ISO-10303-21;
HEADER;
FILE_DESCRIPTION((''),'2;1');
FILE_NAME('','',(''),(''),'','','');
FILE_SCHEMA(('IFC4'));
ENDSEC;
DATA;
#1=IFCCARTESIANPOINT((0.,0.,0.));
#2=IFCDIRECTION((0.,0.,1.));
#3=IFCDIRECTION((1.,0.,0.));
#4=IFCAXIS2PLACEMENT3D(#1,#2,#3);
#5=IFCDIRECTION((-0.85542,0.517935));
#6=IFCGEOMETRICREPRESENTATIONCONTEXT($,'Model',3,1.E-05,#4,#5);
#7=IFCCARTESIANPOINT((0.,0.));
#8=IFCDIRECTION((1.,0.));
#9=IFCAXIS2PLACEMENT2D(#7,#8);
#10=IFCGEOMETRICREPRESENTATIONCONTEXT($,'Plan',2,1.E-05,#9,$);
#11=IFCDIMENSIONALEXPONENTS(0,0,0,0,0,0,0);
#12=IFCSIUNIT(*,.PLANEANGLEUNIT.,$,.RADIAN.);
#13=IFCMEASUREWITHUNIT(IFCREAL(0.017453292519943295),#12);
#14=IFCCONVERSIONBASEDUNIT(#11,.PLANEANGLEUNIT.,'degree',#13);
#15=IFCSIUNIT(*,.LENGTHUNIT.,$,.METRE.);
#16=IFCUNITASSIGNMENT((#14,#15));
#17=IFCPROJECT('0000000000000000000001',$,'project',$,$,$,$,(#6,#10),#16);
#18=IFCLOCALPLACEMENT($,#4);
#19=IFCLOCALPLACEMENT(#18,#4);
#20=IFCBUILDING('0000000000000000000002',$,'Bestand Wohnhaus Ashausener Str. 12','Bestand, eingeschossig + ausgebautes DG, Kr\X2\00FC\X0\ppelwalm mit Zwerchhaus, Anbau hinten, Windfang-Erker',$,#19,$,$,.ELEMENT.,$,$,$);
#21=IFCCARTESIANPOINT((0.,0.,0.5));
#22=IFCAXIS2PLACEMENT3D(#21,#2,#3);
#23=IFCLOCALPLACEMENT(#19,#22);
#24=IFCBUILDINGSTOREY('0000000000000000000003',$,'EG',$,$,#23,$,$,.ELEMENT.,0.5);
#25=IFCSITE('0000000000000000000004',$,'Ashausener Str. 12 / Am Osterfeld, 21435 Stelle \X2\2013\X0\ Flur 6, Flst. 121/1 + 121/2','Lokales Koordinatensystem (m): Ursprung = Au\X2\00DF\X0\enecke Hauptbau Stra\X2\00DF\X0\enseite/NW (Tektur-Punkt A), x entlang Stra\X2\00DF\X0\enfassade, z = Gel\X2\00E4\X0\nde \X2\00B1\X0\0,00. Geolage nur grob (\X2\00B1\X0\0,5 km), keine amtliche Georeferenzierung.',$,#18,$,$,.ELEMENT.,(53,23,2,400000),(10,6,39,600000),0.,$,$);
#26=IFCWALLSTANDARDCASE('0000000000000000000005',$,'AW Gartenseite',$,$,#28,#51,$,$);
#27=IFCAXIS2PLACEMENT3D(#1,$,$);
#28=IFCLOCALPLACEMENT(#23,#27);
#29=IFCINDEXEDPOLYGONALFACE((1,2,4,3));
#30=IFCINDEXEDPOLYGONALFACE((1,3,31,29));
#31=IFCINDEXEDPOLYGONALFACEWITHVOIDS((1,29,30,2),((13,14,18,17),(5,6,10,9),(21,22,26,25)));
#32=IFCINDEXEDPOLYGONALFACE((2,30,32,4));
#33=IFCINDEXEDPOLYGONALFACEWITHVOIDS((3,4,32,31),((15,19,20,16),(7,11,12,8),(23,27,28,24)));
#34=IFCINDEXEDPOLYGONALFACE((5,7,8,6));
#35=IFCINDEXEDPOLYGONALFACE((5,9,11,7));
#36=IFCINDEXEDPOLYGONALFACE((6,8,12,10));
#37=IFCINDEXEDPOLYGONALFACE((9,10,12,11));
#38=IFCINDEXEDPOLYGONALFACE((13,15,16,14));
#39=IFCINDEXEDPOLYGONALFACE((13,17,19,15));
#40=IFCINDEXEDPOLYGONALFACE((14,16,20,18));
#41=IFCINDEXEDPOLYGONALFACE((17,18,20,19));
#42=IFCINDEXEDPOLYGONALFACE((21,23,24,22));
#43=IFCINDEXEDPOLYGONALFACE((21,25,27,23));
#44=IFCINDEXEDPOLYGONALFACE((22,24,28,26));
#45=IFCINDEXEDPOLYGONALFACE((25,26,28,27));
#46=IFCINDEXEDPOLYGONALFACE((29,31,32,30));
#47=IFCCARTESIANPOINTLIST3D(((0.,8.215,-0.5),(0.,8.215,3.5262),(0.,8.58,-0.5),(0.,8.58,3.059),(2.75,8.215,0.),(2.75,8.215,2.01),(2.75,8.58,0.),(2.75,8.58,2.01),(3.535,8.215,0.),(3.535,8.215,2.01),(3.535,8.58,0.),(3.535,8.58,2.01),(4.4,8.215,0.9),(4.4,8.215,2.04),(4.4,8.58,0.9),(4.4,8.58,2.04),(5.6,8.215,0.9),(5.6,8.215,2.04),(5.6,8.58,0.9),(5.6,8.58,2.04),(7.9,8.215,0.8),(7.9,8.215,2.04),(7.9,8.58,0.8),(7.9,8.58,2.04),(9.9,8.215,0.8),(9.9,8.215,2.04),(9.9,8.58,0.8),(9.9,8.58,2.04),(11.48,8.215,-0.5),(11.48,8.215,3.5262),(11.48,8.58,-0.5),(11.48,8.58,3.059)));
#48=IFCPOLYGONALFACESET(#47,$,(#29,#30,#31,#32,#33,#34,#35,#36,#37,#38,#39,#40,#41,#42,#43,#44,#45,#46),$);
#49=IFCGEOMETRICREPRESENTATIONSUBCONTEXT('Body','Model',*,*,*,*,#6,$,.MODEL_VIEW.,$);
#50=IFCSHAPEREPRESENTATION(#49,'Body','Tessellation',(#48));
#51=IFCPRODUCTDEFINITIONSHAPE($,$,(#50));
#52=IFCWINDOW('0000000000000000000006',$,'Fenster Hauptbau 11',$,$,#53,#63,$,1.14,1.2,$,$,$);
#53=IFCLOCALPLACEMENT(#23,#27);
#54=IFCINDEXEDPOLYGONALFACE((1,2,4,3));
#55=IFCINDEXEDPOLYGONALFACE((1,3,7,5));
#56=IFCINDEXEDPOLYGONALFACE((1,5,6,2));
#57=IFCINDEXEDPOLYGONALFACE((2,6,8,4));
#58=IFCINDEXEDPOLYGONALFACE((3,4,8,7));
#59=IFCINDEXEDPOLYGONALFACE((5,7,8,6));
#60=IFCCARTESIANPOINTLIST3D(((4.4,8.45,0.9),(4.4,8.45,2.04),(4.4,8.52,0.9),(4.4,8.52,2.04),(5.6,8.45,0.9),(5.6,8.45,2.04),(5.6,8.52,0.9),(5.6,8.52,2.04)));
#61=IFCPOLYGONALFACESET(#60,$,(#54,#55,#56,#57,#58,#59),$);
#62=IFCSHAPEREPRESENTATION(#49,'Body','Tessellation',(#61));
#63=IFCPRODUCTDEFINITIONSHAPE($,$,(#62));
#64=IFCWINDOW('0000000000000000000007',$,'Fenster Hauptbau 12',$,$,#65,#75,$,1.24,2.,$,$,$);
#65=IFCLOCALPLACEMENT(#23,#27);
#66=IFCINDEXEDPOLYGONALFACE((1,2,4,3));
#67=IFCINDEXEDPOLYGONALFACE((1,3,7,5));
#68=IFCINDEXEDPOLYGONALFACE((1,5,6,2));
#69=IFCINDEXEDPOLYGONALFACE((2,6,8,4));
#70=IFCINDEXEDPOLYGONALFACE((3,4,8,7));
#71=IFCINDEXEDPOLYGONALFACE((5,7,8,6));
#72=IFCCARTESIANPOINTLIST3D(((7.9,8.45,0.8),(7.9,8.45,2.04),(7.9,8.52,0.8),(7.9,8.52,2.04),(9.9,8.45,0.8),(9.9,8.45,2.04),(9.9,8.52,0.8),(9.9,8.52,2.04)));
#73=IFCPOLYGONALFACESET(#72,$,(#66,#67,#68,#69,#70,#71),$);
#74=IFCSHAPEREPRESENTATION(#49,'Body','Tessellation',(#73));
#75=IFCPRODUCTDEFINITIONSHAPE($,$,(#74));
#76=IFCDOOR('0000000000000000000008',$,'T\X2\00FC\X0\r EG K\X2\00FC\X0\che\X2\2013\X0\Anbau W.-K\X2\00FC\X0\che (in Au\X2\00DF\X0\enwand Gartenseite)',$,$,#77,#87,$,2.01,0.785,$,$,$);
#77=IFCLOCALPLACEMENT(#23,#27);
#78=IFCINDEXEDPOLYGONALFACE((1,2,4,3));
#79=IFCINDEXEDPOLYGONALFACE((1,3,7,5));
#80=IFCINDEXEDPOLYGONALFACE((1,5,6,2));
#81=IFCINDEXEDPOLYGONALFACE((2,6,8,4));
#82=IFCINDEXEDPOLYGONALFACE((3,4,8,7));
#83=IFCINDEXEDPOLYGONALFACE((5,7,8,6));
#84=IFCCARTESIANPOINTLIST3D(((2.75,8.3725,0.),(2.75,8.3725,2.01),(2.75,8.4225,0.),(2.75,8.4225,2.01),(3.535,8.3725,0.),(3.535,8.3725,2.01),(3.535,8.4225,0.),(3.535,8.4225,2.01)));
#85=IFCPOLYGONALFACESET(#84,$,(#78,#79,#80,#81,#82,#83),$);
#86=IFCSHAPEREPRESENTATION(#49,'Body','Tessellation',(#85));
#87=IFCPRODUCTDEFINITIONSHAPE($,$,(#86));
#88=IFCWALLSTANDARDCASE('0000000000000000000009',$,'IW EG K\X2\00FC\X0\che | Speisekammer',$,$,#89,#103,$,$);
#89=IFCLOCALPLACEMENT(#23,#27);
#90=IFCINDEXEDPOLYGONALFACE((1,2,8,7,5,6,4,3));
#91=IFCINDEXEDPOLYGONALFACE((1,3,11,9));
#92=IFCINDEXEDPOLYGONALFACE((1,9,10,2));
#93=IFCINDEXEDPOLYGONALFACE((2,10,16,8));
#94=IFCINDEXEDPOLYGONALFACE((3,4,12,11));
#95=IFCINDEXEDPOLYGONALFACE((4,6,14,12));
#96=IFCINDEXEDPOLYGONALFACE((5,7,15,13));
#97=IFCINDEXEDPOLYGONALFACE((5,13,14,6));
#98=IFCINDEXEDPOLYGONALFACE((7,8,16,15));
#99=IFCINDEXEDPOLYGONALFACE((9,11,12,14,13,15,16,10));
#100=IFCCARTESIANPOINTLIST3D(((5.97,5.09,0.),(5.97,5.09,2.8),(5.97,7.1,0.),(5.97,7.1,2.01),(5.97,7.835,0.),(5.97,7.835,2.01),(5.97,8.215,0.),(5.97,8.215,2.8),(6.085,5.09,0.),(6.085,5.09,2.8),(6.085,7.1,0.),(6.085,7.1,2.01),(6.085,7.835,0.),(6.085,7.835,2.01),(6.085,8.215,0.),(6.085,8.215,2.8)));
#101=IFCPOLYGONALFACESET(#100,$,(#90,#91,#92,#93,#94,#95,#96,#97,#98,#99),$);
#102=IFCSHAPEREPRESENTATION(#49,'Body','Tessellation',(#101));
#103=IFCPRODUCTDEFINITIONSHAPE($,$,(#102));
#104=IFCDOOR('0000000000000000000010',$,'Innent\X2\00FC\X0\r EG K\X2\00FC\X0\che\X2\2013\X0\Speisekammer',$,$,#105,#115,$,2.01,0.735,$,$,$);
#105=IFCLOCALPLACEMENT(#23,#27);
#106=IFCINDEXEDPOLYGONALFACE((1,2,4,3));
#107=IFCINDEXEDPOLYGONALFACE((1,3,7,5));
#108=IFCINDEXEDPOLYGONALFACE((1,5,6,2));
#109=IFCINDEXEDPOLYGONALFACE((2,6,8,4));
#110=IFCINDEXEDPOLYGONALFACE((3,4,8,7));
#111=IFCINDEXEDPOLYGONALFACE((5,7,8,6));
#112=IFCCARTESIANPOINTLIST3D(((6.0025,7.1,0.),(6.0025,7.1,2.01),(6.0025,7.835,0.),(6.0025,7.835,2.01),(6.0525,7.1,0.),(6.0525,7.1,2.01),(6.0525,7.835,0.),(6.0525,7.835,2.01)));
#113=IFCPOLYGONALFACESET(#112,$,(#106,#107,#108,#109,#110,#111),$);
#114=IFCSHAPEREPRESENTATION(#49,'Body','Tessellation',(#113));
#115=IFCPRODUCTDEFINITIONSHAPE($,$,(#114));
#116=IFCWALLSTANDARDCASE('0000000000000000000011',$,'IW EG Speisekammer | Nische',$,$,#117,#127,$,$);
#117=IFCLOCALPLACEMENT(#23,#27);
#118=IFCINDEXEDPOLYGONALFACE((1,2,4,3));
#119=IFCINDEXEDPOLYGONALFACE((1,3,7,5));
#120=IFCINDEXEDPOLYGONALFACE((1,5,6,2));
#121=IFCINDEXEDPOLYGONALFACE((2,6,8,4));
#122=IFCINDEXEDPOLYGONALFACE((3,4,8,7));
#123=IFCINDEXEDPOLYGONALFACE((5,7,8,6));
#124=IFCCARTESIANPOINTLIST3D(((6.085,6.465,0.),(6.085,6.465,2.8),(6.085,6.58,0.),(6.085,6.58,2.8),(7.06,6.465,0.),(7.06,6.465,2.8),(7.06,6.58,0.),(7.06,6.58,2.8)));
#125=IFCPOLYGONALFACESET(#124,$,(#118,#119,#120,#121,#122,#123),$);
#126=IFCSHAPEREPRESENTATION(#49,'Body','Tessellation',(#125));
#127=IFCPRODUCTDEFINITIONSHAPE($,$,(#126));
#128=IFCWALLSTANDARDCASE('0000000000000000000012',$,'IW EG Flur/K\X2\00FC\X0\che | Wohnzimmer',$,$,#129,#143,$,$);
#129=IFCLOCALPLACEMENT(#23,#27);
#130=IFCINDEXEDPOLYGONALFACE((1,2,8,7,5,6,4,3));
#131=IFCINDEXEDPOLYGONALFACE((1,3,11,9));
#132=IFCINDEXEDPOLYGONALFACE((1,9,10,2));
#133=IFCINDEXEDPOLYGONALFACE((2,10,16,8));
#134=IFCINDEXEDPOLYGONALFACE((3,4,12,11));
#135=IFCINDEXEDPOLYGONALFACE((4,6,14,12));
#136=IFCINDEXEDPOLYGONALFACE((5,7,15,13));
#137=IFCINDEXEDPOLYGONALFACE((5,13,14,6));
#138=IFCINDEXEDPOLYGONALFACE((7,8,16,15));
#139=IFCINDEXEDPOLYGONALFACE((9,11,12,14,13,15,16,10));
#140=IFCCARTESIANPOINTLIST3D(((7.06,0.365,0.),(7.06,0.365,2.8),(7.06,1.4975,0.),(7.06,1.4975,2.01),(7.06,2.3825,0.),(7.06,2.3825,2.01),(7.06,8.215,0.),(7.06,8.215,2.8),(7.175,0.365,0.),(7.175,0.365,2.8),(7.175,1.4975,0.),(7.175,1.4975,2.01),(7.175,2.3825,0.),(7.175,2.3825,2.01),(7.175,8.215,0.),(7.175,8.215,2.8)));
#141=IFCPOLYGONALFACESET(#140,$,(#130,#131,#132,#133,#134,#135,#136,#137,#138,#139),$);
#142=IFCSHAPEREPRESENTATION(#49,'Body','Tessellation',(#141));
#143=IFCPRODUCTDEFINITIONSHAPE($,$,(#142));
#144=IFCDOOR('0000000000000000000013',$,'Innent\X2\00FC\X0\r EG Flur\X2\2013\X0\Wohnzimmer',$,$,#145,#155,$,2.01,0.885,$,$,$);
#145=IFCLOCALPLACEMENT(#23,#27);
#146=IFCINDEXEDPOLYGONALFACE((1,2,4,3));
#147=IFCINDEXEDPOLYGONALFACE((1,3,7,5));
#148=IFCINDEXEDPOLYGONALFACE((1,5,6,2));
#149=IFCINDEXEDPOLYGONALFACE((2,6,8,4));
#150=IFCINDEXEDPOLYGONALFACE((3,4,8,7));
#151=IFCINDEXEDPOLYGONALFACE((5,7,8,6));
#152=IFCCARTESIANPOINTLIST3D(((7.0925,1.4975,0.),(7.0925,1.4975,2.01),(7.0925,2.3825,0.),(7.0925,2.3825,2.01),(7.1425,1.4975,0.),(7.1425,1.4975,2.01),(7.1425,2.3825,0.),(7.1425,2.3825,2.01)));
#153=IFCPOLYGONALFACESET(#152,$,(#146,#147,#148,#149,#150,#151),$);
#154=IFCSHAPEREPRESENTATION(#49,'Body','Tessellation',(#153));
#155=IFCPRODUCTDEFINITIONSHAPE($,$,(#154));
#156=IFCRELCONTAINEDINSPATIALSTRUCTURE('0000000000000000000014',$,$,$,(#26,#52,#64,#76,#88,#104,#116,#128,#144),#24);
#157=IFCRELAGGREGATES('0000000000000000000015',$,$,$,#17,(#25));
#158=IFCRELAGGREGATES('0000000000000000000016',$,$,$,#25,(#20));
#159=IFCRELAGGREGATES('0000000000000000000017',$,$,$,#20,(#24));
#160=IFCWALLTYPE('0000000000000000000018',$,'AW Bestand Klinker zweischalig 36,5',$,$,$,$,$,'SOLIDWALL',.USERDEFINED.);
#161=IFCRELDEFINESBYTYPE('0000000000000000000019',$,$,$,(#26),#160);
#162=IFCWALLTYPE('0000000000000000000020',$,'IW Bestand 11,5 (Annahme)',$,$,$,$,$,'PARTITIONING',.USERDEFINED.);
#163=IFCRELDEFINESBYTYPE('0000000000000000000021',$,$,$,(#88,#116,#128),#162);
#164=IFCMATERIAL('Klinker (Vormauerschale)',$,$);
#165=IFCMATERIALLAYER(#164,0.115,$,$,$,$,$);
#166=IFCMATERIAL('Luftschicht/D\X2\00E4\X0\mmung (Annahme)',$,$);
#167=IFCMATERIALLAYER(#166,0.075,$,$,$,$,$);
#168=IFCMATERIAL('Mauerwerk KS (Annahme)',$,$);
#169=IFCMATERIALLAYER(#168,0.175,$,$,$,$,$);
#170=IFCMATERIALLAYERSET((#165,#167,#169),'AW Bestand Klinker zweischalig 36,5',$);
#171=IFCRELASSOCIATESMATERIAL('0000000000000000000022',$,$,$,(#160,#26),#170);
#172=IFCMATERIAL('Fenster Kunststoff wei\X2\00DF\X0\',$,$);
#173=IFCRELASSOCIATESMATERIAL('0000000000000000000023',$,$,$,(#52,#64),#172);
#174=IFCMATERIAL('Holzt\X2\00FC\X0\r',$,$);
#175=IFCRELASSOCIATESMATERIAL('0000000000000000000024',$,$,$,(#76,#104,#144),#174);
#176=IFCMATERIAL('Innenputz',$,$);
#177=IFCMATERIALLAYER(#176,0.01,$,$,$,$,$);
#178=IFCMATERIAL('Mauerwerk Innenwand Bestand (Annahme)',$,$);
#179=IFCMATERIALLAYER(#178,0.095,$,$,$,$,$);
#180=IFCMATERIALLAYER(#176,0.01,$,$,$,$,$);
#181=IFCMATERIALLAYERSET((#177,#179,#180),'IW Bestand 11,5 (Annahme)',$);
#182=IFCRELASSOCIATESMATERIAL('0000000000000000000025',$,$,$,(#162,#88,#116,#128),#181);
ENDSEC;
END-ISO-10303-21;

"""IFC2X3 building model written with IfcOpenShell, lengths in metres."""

from ifc_helpers import new_model, entity, si_unit, converted_unit, direction, frame, origin_with_axes, origin_2d_with_axis, place, context, subcontext, project, spatial, polyline, outline, extrude, clip, halfspace, material, layer, layer_set, layer_usage, type_object, element, fill, save


model = new_model("IFC2X3")

# Units and contexts
model_context = context("Model", 3, precision=1e-05, world=origin_with_axes(), true_north=direction((-0.85542, 0.517935)))
plan_context = context("Plan", 2, precision=1e-05, world=origin_2d_with_axis())
body_context = subcontext(model_context, "Body", "Model", "MODEL_VIEW")
ifc_project = project(units=[converted_unit("PLANEANGLEUNIT", "degree", entity("IfcReal", 0.017453292519943295), si_unit("PLANEANGLEUNIT", "RADIAN"), dimensions=[0, 0, 0, 0, 0, 0, 0]), si_unit("LENGTHUNIT", "METRE")], contexts=[model_context, plan_context])

# Site, building, storey
site_placement = place(None, origin_with_axes())
site = spatial("IfcSite", under=ifc_project, at=site_placement, Name="Ashausener Str. 12 / Am Osterfeld, 21435 Stelle – Flur 6, Flst. 121/1 + 121/2", Description="Lokales Koordinatensystem (m): Ursprung = Außenecke Hauptbau Straßenseite/NW (Tektur-Punkt A), x entlang Straßenfassade, z = Gelände ±0,00. Geolage nur grob (±0,5 km), keine amtliche Georeferenzierung.", CompositionType="ELEMENT", RefLatitude=(53, 23, 2, 400000), RefLongitude=(10, 6, 39, 600000), RefElevation=0.0)
building_placement = place(site_placement, origin_with_axes())
building = spatial("IfcBuilding", under=site, at=building_placement, Name="Bestand Wohnhaus Ashausener Str. 12", Description="Bestand, eingeschossig + ausgebautes DG, Krüppelwalm mit Zwerchhaus, Anbau hinten, Windfang-Erker", CompositionType="ELEMENT")
storey_placement = place(building_placement, frame((0.0, 0.0, 0.5), z_axis=(0.0, 0.0, 1.0), x_axis=(1.0, 0.0, 0.0)))
storey = spatial("IfcBuildingStorey", under=building, at=storey_placement, Name="EG", CompositionType="ELEMENT", Elevation=0.5)

# Wall, openings, windows, door
ifc_material_1 = material(Name="Klinker (Vormauerschale)")
ifc_layer_1 = layer(ifc_material_1, 0.115)
ifc_material_2 = material(Name="Luftschicht/Dämmung (Annahme)")
ifc_layer_2 = layer(ifc_material_2, 0.075)
ifc_material_3 = material(Name="Mauerwerk KS (Annahme)")
ifc_layer_3 = layer(ifc_material_3, 0.175)
ifc_layer_set_1 = layer_set([ifc_layer_1, ifc_layer_2, ifc_layer_3], Name="AW Bestand Klinker zweischalig 36,5")
ifc_layer_usage_1 = layer_usage(ifc_layer_set_1, "AXIS2", "POSITIVE", 0.0)
wall_type_1 = type_object("IfcWallType", Name="AW Bestand Klinker zweischalig 36,5", ElementType="SOLIDWALL", PredefinedType="USERDEFINED", material=ifc_layer_set_1)
wall_1_placement = place(storey_placement, frame((11.48, 8.58, -0.5), z_axis=(0.0, 0.0, 1.0), x_axis=(-1.0, 0.0, 0.0)))
wall_1 = element("IfcWallStandardCase", 1, at=wall_1_placement, inside=storey, type_object=wall_type_1, material=ifc_layer_usage_1, Name="AW Gartenseite", context=body_context, shape_type="Clipping", body=[
    clip(clip(clip(clip(extrude(outline(polyline([(0.0, 0.0), (0.0, 0.365), (11.48, 0.365), (11.48, 0.0), (0.0, 0.0)])), origin_with_axes(), (0.0, 0.0, 1.0), 12.0), halfspace(frame((-0.39, 8.58, 5.9), z_axis=(-0.76604, 0.0, 0.64279), x_axis=(0.0, 1.0, 0.0)), False)), halfspace(frame((11.87, 8.58, 5.9), z_axis=(0.76604, 0.0, 0.64279), x_axis=(0.0, -1.0, 0.0)), False)), halfspace(frame((11.48, 4.29, 9.05), z_axis=(0.0, -0.78801, 0.61566), x_axis=(-1.0, 0.0, 0.0)), False)), halfspace(frame((11.48, 4.29, 9.05), z_axis=(0.0, 0.78801, 0.61566), x_axis=(1.0, 0.0, 0.0)), False)),
])
opening_1_placement = place(wall_1_placement, frame((5.88, -0.1, 1.4), z_axis=(0.0, 0.0, 1.0), x_axis=(1.0, 0.0, 0.0)))
opening_1 = element("IfcOpeningElement", 2, at=opening_1_placement, cuts=wall_1, context=body_context, shape_type="SweptSolid", body=[
    extrude(outline(polyline([(0.0, 0.0), (0.0, 0.565), (1.2, 0.565), (1.2, 0.0), (0.0, 0.0)])), origin_with_axes(), (0.0, 0.0, 1.0), 1.14),
])
opening_2_placement = place(wall_1_placement, frame((1.58, -0.1, 1.3), z_axis=(0.0, 0.0, 1.0), x_axis=(1.0, 0.0, 0.0)))
opening_2 = element("IfcOpeningElement", 3, at=opening_2_placement, cuts=wall_1, context=body_context, shape_type="SweptSolid", body=[
    extrude(outline(polyline([(0.0, 0.0), (0.0, 0.565), (2.0, 0.565), (2.0, 0.0), (0.0, 0.0)])), origin_with_axes(), (0.0, 0.0, 1.0), 1.24),
])
opening_3_placement = place(wall_1_placement, frame((7.945, -0.1, 0.5), z_axis=(0.0, 0.0, 1.0), x_axis=(1.0, 0.0, 0.0)))
opening_3 = element("IfcOpeningElement", 4, at=opening_3_placement, cuts=wall_1, context=body_context, shape_type="SweptSolid", body=[
    extrude(outline(polyline([(0.0, 0.0), (0.0, 0.565), (0.785, 0.565), (0.785, 0.0), (0.0, 0.0)])), origin_with_axes(), (0.0, 0.0, 1.0), 2.01),
])
ifc_material_4 = material(Name="Fenster Kunststoff weiß")
window_1_placement = place(storey_placement, frame((5.6, 8.52, 0.9), z_axis=(0.0, 0.0, 1.0), x_axis=(-1.0, 0.0, 0.0)))
window_1 = element("IfcWindow", 5, at=window_1_placement, inside=storey, material=ifc_material_4, Name="Fenster Hauptbau 11", OverallHeight=1.14, OverallWidth=1.2, context=body_context, shape_type="SweptSolid", body=[
    extrude(outline(polyline([(0.0, 0.0), (0.0, 0.07), (1.2, 0.07), (1.2, 0.0), (0.0, 0.0)])), origin_with_axes(), (0.0, 0.0, 1.0), 1.14),
])
fill(opening_1, window_1)
window_2_placement = place(storey_placement, frame((9.9, 8.52, 0.8), z_axis=(0.0, 0.0, 1.0), x_axis=(-1.0, 0.0, 0.0)))
window_2 = element("IfcWindow", 6, at=window_2_placement, inside=storey, material=ifc_material_4, Name="Fenster Hauptbau 12", OverallHeight=1.24, OverallWidth=2.0, context=body_context, shape_type="SweptSolid", body=[
    extrude(outline(polyline([(0.0, 0.0), (0.0, 0.07), (2.0, 0.07), (2.0, 0.0), (0.0, 0.0)])), origin_with_axes(), (0.0, 0.0, 1.0), 1.24),
])
fill(opening_2, window_2)
ifc_material_5 = material(Name="Holztür")
door_1_placement = place(storey_placement, frame((3.535, 8.4225, 0.0), z_axis=(0.0, 0.0, 1.0), x_axis=(-1.0, 0.0, 0.0)))
door_1 = element("IfcDoor", 7, at=door_1_placement, inside=storey, material=ifc_material_5, Name="Tür EG Küche–Anbau W.-Küche (in Außenwand Gartenseite)", OverallHeight=2.01, OverallWidth=0.785, context=body_context, shape_type="SweptSolid", body=[
    extrude(outline(polyline([(0.0, 0.0), (0.0, 0.05), (0.785, 0.05), (0.785, 0.0), (0.0, 0.0)])), origin_with_axes(), (0.0, 0.0, 1.0), 2.01),
])
fill(opening_3, door_1)

# Wall, opening, door
ifc_material_6 = material(Name="Innenputz")
ifc_layer_4 = layer(ifc_material_6, 0.01)
ifc_material_7 = material(Name="Mauerwerk Innenwand Bestand (Annahme)")
ifc_layer_5 = layer(ifc_material_7, 0.095)
ifc_layer_6 = layer(ifc_material_6, 0.01)
ifc_layer_set_2 = layer_set([ifc_layer_4, ifc_layer_5, ifc_layer_6], Name="IW Bestand 11,5 (Annahme)")
ifc_layer_usage_2 = layer_usage(ifc_layer_set_2, "AXIS2", "POSITIVE", 0.0)
wall_type_2 = type_object("IfcWallType", Name="IW Bestand 11,5 (Annahme)", ElementType="PARTITIONING", PredefinedType="USERDEFINED", material=ifc_layer_set_2)
wall_2_placement = place(storey_placement, frame((5.97, 8.215, 0.0), z_axis=(0.0, 0.0, 1.0), x_axis=(0.0, -1.0, 0.0)))
wall_2 = element("IfcWallStandardCase", 8, at=wall_2_placement, inside=storey, type_object=wall_type_2, material=ifc_layer_usage_2, Name="IW EG Küche | Speisekammer", context=body_context, shape_type="SweptSolid", body=[
    extrude(outline(polyline([(0.0, 0.0), (0.0, 0.115), (3.125, 0.115), (3.125, 0.0), (0.0, 0.0)])), origin_with_axes(), (0.0, 0.0, 1.0), 2.8),
])
opening_4_placement = place(wall_2_placement, frame((0.38, -0.1, 0.0), z_axis=(0.0, 0.0, 1.0), x_axis=(1.0, 0.0, 0.0)))
opening_4 = element("IfcOpeningElement", 9, at=opening_4_placement, cuts=wall_2, context=body_context, shape_type="SweptSolid", body=[
    extrude(outline(polyline([(0.0, 0.0), (0.0, 0.315), (0.735, 0.315), (0.735, 0.0), (0.0, 0.0)])), origin_with_axes(), (0.0, 0.0, 1.0), 2.01),
])
door_2_placement = place(storey_placement, frame((6.0025, 7.835, 0.0), z_axis=(0.0, 0.0, 1.0), x_axis=(0.0, -1.0, 0.0)))
door_2 = element("IfcDoor", 10, at=door_2_placement, inside=storey, material=ifc_material_5, Name="Innentür EG Küche–Speisekammer", OverallHeight=2.01, OverallWidth=0.735, context=body_context, shape_type="SweptSolid", body=[
    extrude(outline(polyline([(0.0, 0.0), (0.0, 0.05), (0.735, 0.05), (0.735, 0.0), (0.0, 0.0)])), origin_with_axes(), (0.0, 0.0, 1.0), 2.01),
])
fill(opening_4, door_2)

# Wall
ifc_layer_usage_3 = layer_usage(ifc_layer_set_2, "AXIS2", "POSITIVE", 0.0)
wall_3_placement = place(storey_placement, frame((6.085, 6.465, 0.0), z_axis=(0.0, 0.0, 1.0), x_axis=(1.0, 0.0, 0.0)))
element("IfcWallStandardCase", 11, at=wall_3_placement, inside=storey, type_object=wall_type_2, material=ifc_layer_usage_3, Name="IW EG Speisekammer | Nische", context=body_context, shape_type="SweptSolid", body=[
    extrude(outline(polyline([(0.0, 0.0), (0.0, 0.115), (0.975, 0.115), (0.975, 0.0), (0.0, 0.0)])), origin_with_axes(), (0.0, 0.0, 1.0), 2.8),
])

# Wall, opening, door
ifc_layer_usage_4 = layer_usage(ifc_layer_set_2, "AXIS2", "POSITIVE", 0.0)
wall_4_placement = place(storey_placement, frame((7.06, 8.215, 0.0), z_axis=(0.0, 0.0, 1.0), x_axis=(0.0, -1.0, 0.0)))
wall_4 = element("IfcWallStandardCase", 12, at=wall_4_placement, inside=storey, type_object=wall_type_2, material=ifc_layer_usage_4, Name="IW EG Flur/Küche | Wohnzimmer", context=body_context, shape_type="SweptSolid", body=[
    extrude(outline(polyline([(0.0, 0.0), (0.0, 0.115), (7.85, 0.115), (7.85, 0.0), (0.0, 0.0)])), origin_with_axes(), (0.0, 0.0, 1.0), 2.8),
])
opening_5_placement = place(wall_4_placement, frame((5.8325, -0.1, 0.0), z_axis=(0.0, 0.0, 1.0), x_axis=(1.0, 0.0, 0.0)))
opening_5 = element("IfcOpeningElement", 13, at=opening_5_placement, cuts=wall_4, context=body_context, shape_type="SweptSolid", body=[
    extrude(outline(polyline([(0.0, 0.0), (0.0, 0.315), (0.885, 0.315), (0.885, 0.0), (0.0, 0.0)])), origin_with_axes(), (0.0, 0.0, 1.0), 2.01),
])
door_3_placement = place(storey_placement, frame((7.0925, 2.3825, 0.0), z_axis=(0.0, 0.0, 1.0), x_axis=(0.0, -1.0, 0.0)))
door_3 = element("IfcDoor", 14, at=door_3_placement, inside=storey, material=ifc_material_5, Name="Innentür EG Flur–Wohnzimmer", OverallHeight=2.01, OverallWidth=0.885, context=body_context, shape_type="SweptSolid", body=[
    extrude(outline(polyline([(0.0, 0.0), (0.0, 0.05), (0.885, 0.05), (0.885, 0.0), (0.0, 0.0)])), origin_with_axes(), (0.0, 0.0, 1.0), 2.01),
])
fill(opening_5, door_3)

save(model, "model.ifc")
